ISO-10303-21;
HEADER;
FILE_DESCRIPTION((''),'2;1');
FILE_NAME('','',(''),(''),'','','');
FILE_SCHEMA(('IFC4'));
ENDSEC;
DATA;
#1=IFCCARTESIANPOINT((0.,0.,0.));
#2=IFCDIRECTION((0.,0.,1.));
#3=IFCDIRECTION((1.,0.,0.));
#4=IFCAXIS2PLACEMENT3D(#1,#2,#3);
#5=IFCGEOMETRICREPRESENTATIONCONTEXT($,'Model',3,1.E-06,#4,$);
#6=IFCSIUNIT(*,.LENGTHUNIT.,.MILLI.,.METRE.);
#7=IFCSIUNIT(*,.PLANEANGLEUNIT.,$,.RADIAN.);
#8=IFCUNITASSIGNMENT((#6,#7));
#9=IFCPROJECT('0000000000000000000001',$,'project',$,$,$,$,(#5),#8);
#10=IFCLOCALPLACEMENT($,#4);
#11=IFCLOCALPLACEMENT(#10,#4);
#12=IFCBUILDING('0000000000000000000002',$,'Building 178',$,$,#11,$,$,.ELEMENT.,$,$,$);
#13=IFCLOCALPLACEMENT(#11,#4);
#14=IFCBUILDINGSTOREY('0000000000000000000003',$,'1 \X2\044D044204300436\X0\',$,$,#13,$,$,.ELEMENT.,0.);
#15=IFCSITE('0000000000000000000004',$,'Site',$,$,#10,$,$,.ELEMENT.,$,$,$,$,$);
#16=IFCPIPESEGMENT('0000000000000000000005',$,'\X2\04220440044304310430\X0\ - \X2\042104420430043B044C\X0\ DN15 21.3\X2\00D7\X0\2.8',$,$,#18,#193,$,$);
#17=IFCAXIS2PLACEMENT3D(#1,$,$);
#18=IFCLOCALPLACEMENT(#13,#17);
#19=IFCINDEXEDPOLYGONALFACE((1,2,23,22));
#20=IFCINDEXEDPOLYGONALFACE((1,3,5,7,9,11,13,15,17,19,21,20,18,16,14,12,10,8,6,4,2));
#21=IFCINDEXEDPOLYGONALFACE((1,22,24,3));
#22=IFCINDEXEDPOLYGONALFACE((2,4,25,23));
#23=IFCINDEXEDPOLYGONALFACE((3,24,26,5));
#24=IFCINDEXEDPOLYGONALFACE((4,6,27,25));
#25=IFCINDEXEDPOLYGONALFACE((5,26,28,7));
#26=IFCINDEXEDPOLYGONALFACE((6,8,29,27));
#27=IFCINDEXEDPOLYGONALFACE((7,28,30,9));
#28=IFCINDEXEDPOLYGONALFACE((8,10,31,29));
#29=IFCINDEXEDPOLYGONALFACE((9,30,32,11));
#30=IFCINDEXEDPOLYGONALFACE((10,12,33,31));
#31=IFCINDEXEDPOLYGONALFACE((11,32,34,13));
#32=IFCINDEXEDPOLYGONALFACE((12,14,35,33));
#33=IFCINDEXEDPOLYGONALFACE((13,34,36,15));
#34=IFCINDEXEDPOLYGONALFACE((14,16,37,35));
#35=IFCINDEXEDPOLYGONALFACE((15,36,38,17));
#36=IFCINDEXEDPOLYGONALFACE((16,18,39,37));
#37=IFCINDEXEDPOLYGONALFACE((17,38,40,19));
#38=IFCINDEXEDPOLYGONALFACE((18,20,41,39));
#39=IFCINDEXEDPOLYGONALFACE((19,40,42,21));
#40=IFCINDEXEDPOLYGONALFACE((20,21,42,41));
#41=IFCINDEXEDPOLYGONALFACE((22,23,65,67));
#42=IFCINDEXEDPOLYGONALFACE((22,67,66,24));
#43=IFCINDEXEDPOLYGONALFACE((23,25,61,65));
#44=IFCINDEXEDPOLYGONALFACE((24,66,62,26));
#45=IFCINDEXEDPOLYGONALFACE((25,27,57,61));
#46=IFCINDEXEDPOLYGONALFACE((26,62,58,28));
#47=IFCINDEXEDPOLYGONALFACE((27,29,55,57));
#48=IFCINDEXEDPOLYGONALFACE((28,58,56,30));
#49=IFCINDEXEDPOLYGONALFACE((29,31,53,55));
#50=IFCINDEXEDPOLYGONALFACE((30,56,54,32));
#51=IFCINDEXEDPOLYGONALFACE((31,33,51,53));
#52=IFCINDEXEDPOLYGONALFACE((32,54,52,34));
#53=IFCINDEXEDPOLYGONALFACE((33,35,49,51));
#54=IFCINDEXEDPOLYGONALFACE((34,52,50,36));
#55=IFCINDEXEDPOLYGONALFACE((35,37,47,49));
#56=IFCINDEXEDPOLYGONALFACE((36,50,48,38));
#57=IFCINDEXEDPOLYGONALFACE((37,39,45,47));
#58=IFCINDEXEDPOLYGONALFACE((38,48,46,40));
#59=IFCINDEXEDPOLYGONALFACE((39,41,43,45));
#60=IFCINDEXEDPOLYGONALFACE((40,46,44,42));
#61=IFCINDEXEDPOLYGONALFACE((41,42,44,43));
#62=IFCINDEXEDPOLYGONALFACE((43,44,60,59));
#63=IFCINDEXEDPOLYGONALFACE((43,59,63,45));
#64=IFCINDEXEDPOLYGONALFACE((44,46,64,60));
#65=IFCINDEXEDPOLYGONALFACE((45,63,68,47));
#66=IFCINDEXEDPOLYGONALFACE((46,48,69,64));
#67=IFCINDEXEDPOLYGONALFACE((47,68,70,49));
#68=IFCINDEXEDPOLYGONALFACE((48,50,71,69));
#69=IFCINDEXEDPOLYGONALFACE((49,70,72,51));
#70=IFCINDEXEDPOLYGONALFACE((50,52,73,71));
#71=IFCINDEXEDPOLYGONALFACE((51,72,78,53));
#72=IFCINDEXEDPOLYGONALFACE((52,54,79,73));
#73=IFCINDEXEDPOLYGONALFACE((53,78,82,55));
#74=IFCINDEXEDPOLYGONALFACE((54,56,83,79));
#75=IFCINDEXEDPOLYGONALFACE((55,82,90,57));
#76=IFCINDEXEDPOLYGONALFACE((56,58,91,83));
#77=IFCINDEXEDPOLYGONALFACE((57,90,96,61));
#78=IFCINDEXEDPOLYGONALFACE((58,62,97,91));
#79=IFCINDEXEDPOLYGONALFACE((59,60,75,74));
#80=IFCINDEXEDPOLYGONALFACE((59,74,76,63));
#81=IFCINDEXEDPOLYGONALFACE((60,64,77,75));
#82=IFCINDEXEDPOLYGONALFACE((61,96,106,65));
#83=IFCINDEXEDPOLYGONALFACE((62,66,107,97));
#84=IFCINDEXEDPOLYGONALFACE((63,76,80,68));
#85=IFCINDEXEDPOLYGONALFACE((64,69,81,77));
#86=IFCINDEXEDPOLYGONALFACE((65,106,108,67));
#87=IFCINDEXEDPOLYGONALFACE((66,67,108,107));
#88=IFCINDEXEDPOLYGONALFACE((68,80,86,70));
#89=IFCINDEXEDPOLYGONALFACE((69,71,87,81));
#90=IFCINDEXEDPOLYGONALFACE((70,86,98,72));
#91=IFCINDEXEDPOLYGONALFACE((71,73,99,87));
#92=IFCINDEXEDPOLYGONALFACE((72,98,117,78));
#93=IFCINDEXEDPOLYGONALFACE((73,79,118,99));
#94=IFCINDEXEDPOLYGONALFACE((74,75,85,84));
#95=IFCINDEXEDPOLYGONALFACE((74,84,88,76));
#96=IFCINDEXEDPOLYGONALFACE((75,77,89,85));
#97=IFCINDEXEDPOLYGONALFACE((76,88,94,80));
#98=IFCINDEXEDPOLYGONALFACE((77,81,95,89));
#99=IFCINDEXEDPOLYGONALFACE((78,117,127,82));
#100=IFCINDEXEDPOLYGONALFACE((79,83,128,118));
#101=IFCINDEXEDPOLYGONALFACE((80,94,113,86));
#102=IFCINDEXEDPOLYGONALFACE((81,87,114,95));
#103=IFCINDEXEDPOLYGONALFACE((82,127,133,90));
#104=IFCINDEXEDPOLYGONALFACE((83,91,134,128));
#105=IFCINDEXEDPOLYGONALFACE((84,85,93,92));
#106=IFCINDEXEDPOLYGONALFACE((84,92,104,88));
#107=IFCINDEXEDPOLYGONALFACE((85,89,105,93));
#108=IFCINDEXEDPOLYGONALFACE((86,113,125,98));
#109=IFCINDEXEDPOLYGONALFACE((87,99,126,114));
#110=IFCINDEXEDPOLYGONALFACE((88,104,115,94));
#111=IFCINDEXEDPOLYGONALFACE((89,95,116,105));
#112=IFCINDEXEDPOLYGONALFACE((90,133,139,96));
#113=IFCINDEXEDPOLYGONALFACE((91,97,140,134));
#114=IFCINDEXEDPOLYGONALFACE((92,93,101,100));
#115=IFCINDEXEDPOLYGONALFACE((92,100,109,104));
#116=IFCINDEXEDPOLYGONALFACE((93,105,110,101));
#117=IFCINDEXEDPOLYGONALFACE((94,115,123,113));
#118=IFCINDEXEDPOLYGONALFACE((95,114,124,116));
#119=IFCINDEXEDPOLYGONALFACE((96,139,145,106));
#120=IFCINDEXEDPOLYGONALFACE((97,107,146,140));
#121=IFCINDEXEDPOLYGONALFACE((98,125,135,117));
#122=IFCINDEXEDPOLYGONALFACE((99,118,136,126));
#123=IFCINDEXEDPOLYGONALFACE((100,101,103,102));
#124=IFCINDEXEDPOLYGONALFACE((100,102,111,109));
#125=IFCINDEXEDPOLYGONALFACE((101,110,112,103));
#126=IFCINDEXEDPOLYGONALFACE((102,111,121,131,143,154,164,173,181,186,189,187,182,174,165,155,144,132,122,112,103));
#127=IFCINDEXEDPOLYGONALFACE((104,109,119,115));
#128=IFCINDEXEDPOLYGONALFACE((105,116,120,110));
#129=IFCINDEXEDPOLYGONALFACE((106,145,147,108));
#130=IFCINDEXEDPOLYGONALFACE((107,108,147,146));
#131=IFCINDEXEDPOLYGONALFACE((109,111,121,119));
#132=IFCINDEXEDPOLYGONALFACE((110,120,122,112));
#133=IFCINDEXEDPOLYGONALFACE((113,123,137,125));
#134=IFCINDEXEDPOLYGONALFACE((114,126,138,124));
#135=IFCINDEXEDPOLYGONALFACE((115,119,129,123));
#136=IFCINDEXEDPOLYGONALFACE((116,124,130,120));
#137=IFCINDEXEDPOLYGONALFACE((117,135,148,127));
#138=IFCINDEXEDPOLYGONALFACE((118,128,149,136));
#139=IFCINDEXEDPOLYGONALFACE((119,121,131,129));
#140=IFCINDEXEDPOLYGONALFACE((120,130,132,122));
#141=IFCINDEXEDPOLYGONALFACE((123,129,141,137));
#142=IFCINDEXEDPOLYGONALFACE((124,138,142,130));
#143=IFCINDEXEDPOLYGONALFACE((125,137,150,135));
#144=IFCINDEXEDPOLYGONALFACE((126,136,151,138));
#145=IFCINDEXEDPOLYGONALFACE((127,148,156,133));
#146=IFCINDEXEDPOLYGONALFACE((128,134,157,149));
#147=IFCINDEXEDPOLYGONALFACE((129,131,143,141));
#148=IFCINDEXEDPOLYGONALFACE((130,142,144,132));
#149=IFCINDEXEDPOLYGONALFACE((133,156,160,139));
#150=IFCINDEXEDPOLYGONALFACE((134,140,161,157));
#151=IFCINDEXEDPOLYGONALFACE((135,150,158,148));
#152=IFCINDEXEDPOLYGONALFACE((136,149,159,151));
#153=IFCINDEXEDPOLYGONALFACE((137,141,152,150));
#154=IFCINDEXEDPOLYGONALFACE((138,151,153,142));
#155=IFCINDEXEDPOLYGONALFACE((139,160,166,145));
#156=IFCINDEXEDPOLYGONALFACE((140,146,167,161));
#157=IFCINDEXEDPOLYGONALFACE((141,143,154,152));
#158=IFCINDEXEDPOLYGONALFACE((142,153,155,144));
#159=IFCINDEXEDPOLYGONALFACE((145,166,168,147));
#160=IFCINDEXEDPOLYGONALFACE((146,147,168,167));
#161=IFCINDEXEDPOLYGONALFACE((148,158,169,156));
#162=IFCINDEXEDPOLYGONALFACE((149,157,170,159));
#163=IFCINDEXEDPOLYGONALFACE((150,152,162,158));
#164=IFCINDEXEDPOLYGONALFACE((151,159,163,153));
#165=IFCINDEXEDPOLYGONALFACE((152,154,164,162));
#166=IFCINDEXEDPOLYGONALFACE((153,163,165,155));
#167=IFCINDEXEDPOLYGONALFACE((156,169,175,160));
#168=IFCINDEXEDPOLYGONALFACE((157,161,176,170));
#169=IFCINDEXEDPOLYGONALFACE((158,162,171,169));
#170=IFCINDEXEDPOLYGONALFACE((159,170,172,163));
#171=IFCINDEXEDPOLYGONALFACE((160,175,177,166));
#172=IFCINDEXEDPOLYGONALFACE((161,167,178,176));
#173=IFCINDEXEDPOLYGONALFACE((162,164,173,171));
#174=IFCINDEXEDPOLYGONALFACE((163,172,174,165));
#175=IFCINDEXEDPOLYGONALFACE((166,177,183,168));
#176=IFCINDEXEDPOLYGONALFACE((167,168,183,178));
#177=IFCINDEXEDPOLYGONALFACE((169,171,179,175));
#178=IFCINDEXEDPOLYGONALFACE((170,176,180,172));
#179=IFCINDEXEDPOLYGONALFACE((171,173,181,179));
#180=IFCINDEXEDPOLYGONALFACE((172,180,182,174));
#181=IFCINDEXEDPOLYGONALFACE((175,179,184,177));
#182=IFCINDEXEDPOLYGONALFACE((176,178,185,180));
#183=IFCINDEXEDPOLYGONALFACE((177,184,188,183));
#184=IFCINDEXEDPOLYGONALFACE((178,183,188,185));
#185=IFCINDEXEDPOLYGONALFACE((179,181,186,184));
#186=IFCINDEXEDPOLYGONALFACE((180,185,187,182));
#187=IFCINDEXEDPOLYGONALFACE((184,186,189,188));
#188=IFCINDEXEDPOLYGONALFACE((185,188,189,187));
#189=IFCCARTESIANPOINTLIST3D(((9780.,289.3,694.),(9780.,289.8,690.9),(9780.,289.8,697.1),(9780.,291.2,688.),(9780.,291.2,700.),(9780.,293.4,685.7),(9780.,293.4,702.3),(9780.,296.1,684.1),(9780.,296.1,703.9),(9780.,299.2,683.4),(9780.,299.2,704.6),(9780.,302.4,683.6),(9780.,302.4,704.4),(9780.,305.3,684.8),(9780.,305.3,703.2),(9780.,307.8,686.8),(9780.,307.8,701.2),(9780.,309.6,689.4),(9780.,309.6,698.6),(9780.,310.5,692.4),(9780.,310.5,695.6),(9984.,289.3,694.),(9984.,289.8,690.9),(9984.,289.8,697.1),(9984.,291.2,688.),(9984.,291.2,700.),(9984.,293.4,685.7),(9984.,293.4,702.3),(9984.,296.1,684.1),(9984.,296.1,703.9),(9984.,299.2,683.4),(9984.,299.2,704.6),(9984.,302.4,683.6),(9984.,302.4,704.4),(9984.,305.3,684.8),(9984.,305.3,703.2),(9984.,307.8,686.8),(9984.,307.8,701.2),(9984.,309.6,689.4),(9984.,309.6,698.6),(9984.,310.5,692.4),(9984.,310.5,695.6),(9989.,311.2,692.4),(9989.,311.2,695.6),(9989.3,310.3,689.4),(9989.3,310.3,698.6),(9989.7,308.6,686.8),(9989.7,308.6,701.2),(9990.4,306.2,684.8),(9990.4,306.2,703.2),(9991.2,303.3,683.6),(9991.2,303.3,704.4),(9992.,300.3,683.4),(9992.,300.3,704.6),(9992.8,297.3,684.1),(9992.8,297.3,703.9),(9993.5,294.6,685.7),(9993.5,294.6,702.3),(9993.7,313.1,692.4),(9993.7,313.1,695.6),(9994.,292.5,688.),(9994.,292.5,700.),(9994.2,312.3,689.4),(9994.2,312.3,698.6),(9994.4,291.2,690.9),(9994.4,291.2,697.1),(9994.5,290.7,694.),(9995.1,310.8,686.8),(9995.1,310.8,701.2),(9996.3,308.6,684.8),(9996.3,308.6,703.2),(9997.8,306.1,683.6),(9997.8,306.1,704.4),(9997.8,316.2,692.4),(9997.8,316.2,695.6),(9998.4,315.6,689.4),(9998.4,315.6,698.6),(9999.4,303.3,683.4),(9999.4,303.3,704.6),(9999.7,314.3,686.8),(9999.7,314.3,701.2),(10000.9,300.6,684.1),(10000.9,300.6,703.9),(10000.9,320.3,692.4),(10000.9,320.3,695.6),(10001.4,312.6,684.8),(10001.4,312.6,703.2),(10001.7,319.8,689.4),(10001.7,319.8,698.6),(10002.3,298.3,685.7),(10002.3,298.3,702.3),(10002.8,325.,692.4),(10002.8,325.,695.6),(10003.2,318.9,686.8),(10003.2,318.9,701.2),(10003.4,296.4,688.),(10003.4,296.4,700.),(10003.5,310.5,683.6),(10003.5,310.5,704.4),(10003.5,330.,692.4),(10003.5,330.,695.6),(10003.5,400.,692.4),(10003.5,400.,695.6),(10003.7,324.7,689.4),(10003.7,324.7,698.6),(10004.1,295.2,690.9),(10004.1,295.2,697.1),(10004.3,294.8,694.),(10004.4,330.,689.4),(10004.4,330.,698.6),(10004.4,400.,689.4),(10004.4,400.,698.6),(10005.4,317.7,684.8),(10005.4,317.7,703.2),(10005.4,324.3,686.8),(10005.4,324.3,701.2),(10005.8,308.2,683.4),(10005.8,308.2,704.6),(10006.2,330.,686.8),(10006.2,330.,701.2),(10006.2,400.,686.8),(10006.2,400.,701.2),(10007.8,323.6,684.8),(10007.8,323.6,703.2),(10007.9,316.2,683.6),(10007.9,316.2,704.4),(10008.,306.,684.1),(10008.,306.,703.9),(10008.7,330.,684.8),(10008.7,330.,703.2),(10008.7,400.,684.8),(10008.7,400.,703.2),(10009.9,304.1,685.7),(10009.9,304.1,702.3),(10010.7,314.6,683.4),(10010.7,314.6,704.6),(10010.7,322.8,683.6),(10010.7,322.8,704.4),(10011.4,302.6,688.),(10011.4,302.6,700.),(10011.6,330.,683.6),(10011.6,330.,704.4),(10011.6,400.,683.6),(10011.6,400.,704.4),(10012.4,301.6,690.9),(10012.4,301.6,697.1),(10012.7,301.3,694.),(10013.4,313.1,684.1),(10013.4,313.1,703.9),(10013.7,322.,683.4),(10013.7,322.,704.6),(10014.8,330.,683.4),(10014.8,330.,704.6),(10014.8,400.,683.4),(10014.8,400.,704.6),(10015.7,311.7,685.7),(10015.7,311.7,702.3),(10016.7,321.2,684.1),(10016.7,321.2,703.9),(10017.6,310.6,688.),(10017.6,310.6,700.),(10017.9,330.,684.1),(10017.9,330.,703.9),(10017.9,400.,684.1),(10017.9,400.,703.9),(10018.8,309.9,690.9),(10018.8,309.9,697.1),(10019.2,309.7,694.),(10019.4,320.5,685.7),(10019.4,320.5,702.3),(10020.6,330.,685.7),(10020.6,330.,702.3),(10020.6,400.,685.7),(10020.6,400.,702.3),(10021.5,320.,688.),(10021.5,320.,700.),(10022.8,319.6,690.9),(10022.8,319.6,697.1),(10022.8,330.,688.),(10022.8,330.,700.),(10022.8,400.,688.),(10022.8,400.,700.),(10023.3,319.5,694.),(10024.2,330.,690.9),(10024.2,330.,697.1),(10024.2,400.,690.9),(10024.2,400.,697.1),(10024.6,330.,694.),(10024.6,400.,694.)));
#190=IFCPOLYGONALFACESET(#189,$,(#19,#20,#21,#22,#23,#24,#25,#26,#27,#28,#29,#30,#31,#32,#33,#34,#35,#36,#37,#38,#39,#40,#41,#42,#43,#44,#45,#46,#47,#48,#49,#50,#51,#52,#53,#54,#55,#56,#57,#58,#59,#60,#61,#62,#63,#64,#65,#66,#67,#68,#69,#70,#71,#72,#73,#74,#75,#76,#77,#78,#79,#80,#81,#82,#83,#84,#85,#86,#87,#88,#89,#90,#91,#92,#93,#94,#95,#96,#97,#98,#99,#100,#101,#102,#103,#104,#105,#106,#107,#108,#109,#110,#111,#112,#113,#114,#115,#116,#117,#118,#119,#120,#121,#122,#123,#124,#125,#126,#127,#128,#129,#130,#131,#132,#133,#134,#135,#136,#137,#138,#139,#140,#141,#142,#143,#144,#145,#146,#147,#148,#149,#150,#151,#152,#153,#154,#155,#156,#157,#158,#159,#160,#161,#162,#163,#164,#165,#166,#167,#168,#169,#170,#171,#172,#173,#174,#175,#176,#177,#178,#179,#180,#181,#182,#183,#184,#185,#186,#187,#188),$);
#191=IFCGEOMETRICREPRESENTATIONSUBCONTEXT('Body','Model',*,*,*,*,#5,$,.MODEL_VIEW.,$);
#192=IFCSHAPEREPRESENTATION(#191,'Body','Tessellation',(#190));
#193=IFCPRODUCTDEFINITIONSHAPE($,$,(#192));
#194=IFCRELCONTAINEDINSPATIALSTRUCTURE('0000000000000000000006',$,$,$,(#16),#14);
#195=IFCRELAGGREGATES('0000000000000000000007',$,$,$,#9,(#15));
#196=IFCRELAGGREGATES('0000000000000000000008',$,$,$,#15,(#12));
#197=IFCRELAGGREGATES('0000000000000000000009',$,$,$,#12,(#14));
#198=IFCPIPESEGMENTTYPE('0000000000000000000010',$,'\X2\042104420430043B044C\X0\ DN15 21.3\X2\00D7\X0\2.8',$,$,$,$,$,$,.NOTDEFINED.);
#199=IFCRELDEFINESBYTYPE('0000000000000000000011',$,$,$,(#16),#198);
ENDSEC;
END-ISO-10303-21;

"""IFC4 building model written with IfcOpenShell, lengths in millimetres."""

from ifc_helpers import new_model, entity, si_unit, frame, origin_with_axes, place, context, subcontext, project, spatial, source, transform, mapped, type_object, element, save


model = new_model("IFC4")

# Units and contexts
model_context = context("Model", 3, precision=1e-06, world=origin_with_axes())
body_context = subcontext(model_context, "Body", "Model", "MODEL_VIEW")
ifc_project = project(units=[si_unit("LENGTHUNIT", "METRE", prefix="MILLI"), si_unit("PLANEANGLEUNIT", "RADIAN")], contexts=[model_context])

# Site, building, storey
site_placement = place(None, origin_with_axes())
site = spatial("IfcSite", under=ifc_project, at=site_placement, Name="Site", CompositionType="ELEMENT")
building_placement = place(site_placement, origin_with_axes())
building = spatial("IfcBuilding", under=site, at=building_placement, Name="Building 178", CompositionType="ELEMENT")
storey_placement = place(building_placement, origin_with_axes())
storey = spatial("IfcBuildingStorey", under=building, at=storey_placement, Name="1 этаж", CompositionType="ELEMENT", Elevation=0.0)

# Pipe segment
pipe_segment_type = type_object("IfcPipeSegmentType", Name="Сталь DN15 21.3×2.8", PredefinedType="NOTDEFINED")
shared_shape_1 = source(origin_with_axes(), body_context, "Body", "AdvancedSweptSolid", [
    entity("IfcSweptDiskSolid", entity("IfcIndexedPolyCurve", entity("IfcCartesianPointList3D", [[0.0, 0.0, 0.0], [0.0, 0.0, -70.0], [8.8, 0.0, -91.2], [30.0, 0.0, -100.0], [234.0, 0.0, -100.0]]), [entity("IfcLineIndex", [1, 2]), entity("IfcArcIndex", [2, 3, 4]), entity("IfcLineIndex", [4, 5])]), 10.7),
])
for number, where, z_axis, x_axis, name in (
    (1, (10014.0, 400.0, 694.0), (0.0, 1.0, 0.0), (-1.0, 0.0, 0.0), "Труба - Сталь DN15 21.3×2.8"),
):
    element("IfcPipeSegment", number, at=place(storey_placement, frame(where, z_axis=z_axis, x_axis=x_axis)), inside=storey, type_object=pipe_segment_type, Name=name, context=body_context, shape_type="MappedRepresentation", body=[
        mapped(shared_shape_1, transform((0.0, 0.0, 0.0), x_axis=(1.0, 0.0, 0.0), y_axis=(0.0, 1.0, 0.0), z_axis=(0.0, 0.0, 1.0), scale=1.0)),
    ])

save(model, "model.ifc")
